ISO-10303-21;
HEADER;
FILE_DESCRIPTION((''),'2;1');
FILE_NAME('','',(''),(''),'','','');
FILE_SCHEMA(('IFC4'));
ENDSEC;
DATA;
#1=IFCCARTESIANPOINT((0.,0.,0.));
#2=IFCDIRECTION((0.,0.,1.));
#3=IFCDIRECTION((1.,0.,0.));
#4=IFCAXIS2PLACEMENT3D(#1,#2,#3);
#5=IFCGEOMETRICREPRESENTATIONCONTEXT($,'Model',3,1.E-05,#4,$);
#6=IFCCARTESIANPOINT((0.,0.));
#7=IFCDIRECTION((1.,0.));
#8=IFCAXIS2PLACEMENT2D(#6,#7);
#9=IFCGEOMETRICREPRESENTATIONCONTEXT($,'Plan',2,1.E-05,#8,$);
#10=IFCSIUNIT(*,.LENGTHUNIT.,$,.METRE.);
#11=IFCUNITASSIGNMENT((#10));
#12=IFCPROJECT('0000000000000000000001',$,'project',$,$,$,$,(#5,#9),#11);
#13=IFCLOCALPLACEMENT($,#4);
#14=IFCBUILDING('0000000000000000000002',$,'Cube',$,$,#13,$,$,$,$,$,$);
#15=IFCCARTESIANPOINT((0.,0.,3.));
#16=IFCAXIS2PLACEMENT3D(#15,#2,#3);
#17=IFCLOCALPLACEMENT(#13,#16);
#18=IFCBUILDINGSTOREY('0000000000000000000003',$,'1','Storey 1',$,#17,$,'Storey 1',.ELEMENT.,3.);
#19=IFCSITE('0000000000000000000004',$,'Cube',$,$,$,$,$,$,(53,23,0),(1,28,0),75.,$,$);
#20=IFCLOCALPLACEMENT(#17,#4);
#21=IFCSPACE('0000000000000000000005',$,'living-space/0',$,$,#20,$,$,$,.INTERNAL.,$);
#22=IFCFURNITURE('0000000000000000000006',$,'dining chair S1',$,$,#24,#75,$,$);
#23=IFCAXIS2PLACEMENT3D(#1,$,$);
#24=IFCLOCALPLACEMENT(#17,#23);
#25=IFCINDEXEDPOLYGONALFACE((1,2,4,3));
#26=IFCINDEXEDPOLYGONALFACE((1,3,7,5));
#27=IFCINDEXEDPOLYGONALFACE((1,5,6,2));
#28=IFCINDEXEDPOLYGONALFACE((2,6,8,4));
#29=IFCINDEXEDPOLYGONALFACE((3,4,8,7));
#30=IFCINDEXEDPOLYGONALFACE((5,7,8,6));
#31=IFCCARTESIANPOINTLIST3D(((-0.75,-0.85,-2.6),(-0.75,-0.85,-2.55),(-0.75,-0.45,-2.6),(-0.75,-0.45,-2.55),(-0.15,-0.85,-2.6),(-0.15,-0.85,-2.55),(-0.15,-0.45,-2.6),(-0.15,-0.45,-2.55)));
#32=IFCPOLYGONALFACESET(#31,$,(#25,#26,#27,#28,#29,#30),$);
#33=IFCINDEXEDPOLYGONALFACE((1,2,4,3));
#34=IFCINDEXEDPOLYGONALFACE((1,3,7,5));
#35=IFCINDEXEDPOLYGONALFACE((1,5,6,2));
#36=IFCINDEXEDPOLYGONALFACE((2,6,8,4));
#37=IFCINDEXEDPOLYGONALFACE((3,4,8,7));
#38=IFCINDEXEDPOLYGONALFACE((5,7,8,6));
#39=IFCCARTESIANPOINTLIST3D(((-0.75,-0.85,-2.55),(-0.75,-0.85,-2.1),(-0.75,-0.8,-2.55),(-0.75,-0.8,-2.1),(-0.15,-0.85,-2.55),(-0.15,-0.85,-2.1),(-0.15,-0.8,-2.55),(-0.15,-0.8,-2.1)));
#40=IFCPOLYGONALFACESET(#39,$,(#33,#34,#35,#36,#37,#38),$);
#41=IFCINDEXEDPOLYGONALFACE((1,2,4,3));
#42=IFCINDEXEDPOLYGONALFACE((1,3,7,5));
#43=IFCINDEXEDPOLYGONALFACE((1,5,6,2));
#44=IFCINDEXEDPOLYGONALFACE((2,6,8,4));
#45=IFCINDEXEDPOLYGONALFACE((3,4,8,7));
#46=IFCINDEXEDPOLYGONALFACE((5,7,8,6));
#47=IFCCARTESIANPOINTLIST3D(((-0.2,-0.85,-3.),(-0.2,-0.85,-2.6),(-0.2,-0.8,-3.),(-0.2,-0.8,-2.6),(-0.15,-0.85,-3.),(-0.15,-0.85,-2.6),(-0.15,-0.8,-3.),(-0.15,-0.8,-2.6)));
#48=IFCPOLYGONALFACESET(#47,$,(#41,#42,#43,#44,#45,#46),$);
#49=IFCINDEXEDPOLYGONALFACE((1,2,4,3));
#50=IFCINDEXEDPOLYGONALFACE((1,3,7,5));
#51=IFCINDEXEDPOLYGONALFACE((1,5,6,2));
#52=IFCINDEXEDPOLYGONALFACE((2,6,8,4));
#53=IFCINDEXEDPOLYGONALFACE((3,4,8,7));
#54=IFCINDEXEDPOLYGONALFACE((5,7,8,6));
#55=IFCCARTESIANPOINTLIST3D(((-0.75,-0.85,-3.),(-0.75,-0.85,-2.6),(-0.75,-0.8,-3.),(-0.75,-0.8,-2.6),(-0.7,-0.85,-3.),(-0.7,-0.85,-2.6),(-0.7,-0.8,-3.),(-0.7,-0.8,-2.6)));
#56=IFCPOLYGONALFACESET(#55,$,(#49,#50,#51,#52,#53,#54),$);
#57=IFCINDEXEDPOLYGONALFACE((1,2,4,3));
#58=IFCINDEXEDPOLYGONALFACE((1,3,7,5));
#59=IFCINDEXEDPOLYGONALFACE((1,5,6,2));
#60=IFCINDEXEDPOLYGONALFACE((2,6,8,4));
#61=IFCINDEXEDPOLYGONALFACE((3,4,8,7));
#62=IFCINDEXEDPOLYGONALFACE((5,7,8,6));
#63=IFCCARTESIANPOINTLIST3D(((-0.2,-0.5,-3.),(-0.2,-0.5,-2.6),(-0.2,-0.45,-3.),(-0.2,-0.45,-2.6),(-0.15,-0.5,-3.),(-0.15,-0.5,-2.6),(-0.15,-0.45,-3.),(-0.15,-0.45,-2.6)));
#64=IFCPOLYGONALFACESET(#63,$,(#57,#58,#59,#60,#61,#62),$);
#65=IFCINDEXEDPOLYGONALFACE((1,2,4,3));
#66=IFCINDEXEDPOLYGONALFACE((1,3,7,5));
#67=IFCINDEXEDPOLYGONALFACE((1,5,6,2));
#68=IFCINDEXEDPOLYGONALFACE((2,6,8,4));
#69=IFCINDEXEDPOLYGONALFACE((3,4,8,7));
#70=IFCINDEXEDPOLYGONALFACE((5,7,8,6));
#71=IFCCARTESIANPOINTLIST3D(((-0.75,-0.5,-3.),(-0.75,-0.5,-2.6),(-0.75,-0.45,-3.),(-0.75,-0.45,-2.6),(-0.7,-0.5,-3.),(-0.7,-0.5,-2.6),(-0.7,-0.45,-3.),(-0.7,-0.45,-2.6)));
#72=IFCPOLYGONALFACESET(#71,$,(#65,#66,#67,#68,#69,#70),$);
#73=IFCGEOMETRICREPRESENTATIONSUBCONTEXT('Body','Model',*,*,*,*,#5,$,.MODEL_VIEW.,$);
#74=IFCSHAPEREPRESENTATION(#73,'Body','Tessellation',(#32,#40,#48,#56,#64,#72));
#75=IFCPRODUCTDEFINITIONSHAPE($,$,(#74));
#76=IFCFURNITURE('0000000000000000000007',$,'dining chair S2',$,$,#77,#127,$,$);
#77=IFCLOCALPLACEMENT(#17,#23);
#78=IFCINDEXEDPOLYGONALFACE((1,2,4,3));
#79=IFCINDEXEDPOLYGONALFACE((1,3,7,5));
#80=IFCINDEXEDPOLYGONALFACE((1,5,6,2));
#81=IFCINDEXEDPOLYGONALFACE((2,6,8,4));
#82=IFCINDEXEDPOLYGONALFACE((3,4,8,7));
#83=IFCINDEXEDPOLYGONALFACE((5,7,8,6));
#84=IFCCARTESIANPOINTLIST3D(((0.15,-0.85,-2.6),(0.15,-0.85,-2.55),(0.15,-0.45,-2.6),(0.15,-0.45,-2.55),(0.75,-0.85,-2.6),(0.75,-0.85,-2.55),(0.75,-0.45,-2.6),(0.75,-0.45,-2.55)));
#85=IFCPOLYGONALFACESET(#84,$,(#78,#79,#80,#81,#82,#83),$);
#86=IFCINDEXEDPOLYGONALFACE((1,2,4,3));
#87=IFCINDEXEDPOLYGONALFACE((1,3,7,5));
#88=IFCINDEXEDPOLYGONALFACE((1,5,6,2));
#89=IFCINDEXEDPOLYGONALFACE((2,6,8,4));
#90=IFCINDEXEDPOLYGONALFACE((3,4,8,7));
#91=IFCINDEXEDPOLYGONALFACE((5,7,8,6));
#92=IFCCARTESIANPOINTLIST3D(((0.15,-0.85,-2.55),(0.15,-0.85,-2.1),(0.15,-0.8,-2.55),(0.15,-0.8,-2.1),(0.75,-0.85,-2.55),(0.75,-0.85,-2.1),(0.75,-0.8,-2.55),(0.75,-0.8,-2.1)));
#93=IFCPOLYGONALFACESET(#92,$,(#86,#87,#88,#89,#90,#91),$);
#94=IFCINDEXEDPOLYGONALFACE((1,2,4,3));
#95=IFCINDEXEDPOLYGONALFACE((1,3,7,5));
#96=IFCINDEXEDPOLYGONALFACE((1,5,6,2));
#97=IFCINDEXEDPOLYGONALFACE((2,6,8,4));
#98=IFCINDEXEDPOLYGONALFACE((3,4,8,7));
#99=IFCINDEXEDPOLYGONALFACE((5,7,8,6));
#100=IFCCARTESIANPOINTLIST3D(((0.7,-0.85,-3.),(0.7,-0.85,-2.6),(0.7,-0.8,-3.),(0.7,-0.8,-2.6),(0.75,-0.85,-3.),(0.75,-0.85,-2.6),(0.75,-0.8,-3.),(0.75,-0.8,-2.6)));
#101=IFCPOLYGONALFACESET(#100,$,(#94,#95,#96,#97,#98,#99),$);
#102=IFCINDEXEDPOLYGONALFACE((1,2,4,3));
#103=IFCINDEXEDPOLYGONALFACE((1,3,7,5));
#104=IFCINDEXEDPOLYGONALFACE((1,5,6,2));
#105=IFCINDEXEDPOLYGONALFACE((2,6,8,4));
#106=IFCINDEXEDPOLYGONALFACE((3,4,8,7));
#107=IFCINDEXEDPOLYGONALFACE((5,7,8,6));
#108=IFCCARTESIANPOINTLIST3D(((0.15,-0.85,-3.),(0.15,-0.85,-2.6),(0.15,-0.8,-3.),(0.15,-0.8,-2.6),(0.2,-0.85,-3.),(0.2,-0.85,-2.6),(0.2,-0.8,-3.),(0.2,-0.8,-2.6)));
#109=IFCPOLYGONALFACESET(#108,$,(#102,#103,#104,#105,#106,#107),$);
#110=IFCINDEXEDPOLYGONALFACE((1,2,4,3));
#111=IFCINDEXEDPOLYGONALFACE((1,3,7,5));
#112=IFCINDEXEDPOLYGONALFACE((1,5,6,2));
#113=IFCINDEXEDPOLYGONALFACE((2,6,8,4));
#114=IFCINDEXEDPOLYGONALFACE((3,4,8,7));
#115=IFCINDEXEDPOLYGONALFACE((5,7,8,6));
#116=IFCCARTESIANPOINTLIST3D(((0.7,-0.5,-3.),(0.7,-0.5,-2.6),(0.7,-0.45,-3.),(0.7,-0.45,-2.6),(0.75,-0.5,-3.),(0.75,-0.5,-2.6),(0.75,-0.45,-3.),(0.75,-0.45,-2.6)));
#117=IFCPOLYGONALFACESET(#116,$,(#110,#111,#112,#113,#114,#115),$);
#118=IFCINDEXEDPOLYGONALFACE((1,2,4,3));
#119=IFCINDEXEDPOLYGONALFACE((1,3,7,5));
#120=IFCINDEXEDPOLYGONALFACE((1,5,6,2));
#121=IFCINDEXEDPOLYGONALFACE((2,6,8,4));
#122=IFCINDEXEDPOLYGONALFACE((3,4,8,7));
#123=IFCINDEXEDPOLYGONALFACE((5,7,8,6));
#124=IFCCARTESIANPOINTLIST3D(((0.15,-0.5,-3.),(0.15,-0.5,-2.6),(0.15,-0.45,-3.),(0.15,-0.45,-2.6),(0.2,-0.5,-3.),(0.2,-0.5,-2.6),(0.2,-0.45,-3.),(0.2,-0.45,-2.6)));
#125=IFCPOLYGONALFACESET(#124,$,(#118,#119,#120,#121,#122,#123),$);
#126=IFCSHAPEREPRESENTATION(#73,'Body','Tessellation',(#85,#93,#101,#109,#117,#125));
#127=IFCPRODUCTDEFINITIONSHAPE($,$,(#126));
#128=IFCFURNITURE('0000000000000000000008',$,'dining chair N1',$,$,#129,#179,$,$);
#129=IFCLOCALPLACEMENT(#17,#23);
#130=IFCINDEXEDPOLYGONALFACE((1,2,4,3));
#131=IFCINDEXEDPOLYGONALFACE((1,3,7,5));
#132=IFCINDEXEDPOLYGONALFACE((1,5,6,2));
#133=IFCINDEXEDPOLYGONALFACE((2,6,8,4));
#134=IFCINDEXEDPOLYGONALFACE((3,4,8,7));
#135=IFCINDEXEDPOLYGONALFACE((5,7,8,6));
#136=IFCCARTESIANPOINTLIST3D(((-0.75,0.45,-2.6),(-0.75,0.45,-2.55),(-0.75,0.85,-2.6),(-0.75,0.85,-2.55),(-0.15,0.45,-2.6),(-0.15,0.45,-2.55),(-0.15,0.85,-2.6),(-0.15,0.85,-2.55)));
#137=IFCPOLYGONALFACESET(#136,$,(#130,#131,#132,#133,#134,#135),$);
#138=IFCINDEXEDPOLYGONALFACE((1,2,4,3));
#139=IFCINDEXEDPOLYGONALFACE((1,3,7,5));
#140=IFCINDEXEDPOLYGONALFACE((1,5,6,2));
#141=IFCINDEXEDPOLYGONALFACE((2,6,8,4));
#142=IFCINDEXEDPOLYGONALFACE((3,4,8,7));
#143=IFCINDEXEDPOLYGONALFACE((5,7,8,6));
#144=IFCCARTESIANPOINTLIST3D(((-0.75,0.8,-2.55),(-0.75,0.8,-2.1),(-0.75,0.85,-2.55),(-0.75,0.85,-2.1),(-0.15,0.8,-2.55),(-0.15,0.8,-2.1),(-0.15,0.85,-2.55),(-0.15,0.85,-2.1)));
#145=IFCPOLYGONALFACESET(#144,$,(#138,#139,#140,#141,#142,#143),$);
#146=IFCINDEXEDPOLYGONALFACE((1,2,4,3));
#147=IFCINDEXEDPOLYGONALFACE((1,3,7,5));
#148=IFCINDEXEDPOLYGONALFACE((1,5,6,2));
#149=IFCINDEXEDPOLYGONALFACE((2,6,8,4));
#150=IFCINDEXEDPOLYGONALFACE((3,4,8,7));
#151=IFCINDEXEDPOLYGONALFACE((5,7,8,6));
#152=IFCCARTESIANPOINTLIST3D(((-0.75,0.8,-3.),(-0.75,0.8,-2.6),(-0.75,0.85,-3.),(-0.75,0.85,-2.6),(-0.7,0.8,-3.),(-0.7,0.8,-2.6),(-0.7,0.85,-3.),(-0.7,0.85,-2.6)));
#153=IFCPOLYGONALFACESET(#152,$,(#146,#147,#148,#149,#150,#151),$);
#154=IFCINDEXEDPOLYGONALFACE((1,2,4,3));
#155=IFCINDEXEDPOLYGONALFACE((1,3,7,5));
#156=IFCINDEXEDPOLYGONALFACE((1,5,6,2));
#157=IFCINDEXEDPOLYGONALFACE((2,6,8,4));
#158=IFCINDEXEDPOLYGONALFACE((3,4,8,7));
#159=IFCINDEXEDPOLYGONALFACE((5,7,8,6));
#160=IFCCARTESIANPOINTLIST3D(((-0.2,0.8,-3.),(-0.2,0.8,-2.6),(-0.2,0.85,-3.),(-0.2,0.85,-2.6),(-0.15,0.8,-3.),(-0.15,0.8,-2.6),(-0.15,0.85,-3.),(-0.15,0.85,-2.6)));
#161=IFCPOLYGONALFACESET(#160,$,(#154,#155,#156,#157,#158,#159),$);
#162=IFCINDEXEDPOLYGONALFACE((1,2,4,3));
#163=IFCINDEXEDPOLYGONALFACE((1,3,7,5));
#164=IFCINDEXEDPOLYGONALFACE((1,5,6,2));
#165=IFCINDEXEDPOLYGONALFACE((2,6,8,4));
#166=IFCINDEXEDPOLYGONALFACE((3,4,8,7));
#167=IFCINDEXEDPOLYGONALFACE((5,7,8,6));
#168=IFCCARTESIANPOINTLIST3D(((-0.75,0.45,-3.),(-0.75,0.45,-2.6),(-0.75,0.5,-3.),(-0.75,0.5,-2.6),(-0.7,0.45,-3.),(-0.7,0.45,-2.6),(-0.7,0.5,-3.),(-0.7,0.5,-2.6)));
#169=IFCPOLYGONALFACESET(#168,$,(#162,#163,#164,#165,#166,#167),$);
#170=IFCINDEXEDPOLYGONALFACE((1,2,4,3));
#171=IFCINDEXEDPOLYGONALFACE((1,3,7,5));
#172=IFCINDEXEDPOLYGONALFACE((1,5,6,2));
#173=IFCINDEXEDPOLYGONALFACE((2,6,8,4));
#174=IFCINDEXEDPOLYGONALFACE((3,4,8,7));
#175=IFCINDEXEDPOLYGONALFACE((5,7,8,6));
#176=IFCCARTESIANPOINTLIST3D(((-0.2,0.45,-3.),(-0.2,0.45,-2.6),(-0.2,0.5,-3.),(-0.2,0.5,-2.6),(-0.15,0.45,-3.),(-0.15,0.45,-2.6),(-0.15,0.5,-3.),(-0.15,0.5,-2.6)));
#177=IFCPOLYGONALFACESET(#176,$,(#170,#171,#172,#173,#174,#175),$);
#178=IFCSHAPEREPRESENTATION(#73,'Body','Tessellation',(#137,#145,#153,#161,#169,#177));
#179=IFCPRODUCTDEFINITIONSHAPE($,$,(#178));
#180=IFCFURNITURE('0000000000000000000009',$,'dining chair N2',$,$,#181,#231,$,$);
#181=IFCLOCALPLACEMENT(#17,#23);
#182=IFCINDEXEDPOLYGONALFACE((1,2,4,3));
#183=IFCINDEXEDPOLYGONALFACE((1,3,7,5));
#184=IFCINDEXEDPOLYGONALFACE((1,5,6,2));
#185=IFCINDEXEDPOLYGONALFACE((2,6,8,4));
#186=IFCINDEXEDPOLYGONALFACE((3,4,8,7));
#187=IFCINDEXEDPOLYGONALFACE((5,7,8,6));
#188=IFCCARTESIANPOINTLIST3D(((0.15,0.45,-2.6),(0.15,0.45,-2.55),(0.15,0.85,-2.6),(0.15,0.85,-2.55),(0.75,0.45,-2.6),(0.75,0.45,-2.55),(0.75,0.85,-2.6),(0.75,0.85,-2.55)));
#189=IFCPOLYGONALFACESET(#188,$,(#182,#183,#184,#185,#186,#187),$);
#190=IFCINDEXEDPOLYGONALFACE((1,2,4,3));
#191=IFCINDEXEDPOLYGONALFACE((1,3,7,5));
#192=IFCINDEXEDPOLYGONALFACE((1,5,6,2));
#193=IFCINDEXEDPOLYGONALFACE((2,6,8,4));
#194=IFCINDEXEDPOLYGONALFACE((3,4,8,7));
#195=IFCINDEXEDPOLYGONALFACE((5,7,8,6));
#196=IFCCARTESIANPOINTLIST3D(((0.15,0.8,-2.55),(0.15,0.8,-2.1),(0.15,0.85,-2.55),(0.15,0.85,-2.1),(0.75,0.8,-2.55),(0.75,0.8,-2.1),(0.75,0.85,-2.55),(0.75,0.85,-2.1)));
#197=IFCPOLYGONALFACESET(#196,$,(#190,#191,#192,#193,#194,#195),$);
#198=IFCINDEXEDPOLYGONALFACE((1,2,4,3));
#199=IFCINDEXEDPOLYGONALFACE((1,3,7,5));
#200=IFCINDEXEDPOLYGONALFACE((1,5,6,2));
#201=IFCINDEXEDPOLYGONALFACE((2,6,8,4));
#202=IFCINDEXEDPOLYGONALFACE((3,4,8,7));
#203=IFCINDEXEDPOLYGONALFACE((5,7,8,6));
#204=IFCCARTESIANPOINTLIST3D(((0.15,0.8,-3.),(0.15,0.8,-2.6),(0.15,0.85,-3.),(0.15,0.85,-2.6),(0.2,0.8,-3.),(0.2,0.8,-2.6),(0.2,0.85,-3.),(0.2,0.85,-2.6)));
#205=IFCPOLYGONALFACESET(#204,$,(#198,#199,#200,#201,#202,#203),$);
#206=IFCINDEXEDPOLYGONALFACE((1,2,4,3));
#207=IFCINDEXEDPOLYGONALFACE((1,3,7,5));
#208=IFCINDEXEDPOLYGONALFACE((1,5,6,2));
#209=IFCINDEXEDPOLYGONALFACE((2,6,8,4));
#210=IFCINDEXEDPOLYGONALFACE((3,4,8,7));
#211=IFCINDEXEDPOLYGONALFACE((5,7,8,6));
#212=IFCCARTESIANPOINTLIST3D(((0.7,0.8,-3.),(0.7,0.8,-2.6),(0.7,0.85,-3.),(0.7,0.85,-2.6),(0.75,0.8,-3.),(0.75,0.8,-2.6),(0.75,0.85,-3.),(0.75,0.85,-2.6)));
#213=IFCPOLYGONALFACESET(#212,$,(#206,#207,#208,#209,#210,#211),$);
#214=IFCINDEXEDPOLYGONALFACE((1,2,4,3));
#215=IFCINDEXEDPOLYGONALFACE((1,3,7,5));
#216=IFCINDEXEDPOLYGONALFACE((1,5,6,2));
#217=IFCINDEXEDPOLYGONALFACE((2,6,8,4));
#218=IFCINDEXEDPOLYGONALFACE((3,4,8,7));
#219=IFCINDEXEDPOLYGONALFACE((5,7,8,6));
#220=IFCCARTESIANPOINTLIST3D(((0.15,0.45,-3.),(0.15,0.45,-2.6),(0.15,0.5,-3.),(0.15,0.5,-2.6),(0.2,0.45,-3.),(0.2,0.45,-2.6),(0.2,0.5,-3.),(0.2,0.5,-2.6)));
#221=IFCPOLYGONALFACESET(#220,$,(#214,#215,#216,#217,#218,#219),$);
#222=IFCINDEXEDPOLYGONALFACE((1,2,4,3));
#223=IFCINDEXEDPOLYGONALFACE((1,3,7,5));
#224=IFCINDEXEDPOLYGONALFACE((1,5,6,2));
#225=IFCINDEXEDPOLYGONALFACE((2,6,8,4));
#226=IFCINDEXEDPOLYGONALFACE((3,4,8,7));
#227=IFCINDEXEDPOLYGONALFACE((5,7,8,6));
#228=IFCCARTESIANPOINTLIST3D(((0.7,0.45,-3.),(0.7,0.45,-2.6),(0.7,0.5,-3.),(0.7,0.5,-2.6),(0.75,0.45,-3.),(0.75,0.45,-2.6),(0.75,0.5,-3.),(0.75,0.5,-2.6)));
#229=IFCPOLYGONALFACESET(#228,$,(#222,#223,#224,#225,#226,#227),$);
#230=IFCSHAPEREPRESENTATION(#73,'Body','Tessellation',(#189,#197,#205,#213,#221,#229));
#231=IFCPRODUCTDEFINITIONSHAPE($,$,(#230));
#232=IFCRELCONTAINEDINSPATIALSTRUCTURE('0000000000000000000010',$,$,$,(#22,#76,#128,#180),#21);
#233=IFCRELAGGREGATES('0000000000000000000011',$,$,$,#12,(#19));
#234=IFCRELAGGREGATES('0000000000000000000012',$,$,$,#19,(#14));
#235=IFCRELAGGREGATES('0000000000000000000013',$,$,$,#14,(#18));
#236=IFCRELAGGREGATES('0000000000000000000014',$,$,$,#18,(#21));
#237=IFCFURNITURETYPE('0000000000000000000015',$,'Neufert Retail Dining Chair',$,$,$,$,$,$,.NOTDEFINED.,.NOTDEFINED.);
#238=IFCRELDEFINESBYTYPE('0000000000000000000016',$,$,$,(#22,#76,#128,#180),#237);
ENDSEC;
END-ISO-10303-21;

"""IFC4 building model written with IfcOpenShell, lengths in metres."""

from ifc_helpers import new_model, entity, si_unit, frame, origin_with_axes, origin_2d_with_axis, place, context, subcontext, project, spatial, line, indexed_curve, outline, extrude, shape, source, transform, mapped, type_object, type_shapes, element, save


model = new_model("IFC4")

# Units and contexts
model_context = context("Model", 3, precision=1e-05, world=origin_with_axes())
plan_context = context("Plan", 2, precision=1e-05, world=origin_2d_with_axis())
body_context_1 = subcontext(model_context, "Body", "Model", "MODEL_VIEW")
body_context_2 = subcontext(plan_context, "Body", "Plan", "PLAN_VIEW")
ifc_project = project(units=[si_unit("LENGTHUNIT", "METRE")], contexts=[model_context, plan_context])

# Site, building, storey
site = spatial("IfcSite", under=ifc_project, Name="Cube", RefLatitude=(53, 23, 0), RefLongitude=(1, 28, 0), RefElevation=75.0)
building_placement = place(None, origin_with_axes())
building = spatial("IfcBuilding", under=site, at=building_placement, Name="Cube")
storey_placement = place(building_placement, frame((0.0, 0.0, 3.0), z_axis=(0.0, 0.0, 1.0), x_axis=(1.0, 0.0, 0.0)))
storey = spatial("IfcBuildingStorey", under=building, at=storey_placement, Name="1", Description="Storey 1", LongName="Storey 1", CompositionType="ELEMENT", Elevation=3.0)

# Shared definitions
space_placement = place(storey_placement, origin_with_axes())
space = spatial("IfcSpace", under=storey, at=space_placement, Name="living-space/0", PredefinedType="INTERNAL")

# Furniture
furniture_type_1 = type_object("IfcFurnitureType", Name="Neufert Retail Dining Chair", AssemblyPlace="NOTDEFINED", PredefinedType="NOTDEFINED")
shared_shape_1 = source(origin_with_axes(), body_context_1, "Body", "SweptSolid", [
    extrude(outline(indexed_curve([(-0.3, 0.0), (0.3, 0.0), (0.3, -0.4), (-0.3, -0.4)], segments=[line(1, 2, 3, 4, 1)])), frame((0.0, 0.0, 0.45), z_axis=(0.0, 0.0, 1.0), x_axis=(1.0, 0.0, 0.0)), (0.0, 0.0, -1.0), 0.05),
    extrude(outline(indexed_curve([(-0.3, 0.0), (0.3, 0.0), (0.3, -0.05), (-0.3, -0.05)], segments=[line(1, 2, 3, 4, 1)])), frame((0.0, 0.0, 0.9), z_axis=(0.0, 0.0, 1.0), x_axis=(1.0, 0.0, 0.0)), (0.0, 0.0, -1.0), 0.45),
    extrude(outline(indexed_curve([(-0.3, 0.0), (-0.25, 0.0), (-0.25, -0.05), (-0.3, -0.05)], segments=[line(1, 2, 3, 4, 1)])), origin_with_axes(), (0.0, 0.0, 1.0), 0.4),
    extrude(outline(indexed_curve([(0.3, 0.0), (0.25, 0.0), (0.25, -0.05), (0.3, -0.05)], segments=[line(1, 2, 3, 4, 1)])), origin_with_axes(), (0.0, 0.0, 1.0), 0.4),
    extrude(outline(indexed_curve([(-0.3, -0.4), (-0.25, -0.4), (-0.25, -0.35), (-0.3, -0.35)], segments=[line(1, 2, 3, 4, 1)])), origin_with_axes(), (0.0, 0.0, 1.0), 0.4),
    extrude(outline(indexed_curve([(0.3, -0.4), (0.25, -0.4), (0.25, -0.35), (0.3, -0.35)], segments=[line(1, 2, 3, 4, 1)])), origin_with_axes(), (0.0, 0.0, 1.0), 0.4),
])
shared_shape_2 = source(origin_with_axes(), body_context_2, "Body", "Curve2D", [
    entity("IfcIndexedPolyCurve", entity("IfcCartesianPointList2D", [[-0.3, -0.4], [0.3, -0.4]])),
    entity("IfcIndexedPolyCurve", entity("IfcCartesianPointList2D", [[-0.3, -0.4], [-0.3, -0.3], [-0.2121, -0.0879], [0.0, 0.0], [0.2121, -0.0879], [0.3, -0.3], [0.3, -0.4]]), [entity("IfcLineIndex", [1, 2]), entity("IfcArcIndex", [2, 3, 4]), entity("IfcArcIndex", [4, 5, 6]), entity("IfcLineIndex", [6, 7])]),
    entity("IfcIndexedPolyCurve", entity("IfcCartesianPointList2D", [[-0.26, -0.4], [-0.26, -0.3], [-0.1838, -0.1162], [0.0, -0.04], [0.1838, -0.1162], [0.26, -0.3], [0.26, -0.4]]), [entity("IfcLineIndex", [1, 2]), entity("IfcArcIndex", [2, 3, 4]), entity("IfcArcIndex", [4, 5, 6]), entity("IfcLineIndex", [6, 7])]),
])
type_shapes(furniture_type_1, [shared_shape_1, shared_shape_2])
for number, where, z_axis, x_axis, name in (
    (1, (-0.45, -0.85, -3.0), (0.0, 0.0, 1.0), (-1.0, 0.0, 0.0), "dining chair S1"),
    (2, (0.45, -0.85, -3.0), (0.0, 0.0, 1.0), (-1.0, 0.0, 0.0), "dining chair S2"),
    (3, (-0.45, 0.85, -3.0), (0.0, 0.0, 1.0), (1.0, 0.0, 0.0), "dining chair N1"),
    (4, (0.45, 0.85, -3.0), (0.0, 0.0, 1.0), (1.0, 0.0, 0.0), "dining chair N2"),
):
    element("IfcFurniture", number, at=place(space_placement, frame(where, z_axis=z_axis, x_axis=x_axis)), inside=space, type_object=furniture_type_1, Name=name, shapes=[
        shape(body_context_1, "Body", "MappedRepresentation", [mapped(shared_shape_1, transform((0.0, 0.0, 0.0), x_axis=(1.0, 0.0, 0.0), y_axis=(0.0, 1.0, 0.0), z_axis=(0.0, 0.0, 1.0), scale=1.0))]),
        shape(body_context_2, "Body", "MappedRepresentation", [mapped(shared_shape_2, transform((0.0, 0.0, 0.0), x_axis=(1.0, 0.0, 0.0), y_axis=(0.0, 1.0, 0.0), z_axis=(0.0, 0.0, 1.0), scale=1.0))]),
    ])

save(model, "model.ifc")
